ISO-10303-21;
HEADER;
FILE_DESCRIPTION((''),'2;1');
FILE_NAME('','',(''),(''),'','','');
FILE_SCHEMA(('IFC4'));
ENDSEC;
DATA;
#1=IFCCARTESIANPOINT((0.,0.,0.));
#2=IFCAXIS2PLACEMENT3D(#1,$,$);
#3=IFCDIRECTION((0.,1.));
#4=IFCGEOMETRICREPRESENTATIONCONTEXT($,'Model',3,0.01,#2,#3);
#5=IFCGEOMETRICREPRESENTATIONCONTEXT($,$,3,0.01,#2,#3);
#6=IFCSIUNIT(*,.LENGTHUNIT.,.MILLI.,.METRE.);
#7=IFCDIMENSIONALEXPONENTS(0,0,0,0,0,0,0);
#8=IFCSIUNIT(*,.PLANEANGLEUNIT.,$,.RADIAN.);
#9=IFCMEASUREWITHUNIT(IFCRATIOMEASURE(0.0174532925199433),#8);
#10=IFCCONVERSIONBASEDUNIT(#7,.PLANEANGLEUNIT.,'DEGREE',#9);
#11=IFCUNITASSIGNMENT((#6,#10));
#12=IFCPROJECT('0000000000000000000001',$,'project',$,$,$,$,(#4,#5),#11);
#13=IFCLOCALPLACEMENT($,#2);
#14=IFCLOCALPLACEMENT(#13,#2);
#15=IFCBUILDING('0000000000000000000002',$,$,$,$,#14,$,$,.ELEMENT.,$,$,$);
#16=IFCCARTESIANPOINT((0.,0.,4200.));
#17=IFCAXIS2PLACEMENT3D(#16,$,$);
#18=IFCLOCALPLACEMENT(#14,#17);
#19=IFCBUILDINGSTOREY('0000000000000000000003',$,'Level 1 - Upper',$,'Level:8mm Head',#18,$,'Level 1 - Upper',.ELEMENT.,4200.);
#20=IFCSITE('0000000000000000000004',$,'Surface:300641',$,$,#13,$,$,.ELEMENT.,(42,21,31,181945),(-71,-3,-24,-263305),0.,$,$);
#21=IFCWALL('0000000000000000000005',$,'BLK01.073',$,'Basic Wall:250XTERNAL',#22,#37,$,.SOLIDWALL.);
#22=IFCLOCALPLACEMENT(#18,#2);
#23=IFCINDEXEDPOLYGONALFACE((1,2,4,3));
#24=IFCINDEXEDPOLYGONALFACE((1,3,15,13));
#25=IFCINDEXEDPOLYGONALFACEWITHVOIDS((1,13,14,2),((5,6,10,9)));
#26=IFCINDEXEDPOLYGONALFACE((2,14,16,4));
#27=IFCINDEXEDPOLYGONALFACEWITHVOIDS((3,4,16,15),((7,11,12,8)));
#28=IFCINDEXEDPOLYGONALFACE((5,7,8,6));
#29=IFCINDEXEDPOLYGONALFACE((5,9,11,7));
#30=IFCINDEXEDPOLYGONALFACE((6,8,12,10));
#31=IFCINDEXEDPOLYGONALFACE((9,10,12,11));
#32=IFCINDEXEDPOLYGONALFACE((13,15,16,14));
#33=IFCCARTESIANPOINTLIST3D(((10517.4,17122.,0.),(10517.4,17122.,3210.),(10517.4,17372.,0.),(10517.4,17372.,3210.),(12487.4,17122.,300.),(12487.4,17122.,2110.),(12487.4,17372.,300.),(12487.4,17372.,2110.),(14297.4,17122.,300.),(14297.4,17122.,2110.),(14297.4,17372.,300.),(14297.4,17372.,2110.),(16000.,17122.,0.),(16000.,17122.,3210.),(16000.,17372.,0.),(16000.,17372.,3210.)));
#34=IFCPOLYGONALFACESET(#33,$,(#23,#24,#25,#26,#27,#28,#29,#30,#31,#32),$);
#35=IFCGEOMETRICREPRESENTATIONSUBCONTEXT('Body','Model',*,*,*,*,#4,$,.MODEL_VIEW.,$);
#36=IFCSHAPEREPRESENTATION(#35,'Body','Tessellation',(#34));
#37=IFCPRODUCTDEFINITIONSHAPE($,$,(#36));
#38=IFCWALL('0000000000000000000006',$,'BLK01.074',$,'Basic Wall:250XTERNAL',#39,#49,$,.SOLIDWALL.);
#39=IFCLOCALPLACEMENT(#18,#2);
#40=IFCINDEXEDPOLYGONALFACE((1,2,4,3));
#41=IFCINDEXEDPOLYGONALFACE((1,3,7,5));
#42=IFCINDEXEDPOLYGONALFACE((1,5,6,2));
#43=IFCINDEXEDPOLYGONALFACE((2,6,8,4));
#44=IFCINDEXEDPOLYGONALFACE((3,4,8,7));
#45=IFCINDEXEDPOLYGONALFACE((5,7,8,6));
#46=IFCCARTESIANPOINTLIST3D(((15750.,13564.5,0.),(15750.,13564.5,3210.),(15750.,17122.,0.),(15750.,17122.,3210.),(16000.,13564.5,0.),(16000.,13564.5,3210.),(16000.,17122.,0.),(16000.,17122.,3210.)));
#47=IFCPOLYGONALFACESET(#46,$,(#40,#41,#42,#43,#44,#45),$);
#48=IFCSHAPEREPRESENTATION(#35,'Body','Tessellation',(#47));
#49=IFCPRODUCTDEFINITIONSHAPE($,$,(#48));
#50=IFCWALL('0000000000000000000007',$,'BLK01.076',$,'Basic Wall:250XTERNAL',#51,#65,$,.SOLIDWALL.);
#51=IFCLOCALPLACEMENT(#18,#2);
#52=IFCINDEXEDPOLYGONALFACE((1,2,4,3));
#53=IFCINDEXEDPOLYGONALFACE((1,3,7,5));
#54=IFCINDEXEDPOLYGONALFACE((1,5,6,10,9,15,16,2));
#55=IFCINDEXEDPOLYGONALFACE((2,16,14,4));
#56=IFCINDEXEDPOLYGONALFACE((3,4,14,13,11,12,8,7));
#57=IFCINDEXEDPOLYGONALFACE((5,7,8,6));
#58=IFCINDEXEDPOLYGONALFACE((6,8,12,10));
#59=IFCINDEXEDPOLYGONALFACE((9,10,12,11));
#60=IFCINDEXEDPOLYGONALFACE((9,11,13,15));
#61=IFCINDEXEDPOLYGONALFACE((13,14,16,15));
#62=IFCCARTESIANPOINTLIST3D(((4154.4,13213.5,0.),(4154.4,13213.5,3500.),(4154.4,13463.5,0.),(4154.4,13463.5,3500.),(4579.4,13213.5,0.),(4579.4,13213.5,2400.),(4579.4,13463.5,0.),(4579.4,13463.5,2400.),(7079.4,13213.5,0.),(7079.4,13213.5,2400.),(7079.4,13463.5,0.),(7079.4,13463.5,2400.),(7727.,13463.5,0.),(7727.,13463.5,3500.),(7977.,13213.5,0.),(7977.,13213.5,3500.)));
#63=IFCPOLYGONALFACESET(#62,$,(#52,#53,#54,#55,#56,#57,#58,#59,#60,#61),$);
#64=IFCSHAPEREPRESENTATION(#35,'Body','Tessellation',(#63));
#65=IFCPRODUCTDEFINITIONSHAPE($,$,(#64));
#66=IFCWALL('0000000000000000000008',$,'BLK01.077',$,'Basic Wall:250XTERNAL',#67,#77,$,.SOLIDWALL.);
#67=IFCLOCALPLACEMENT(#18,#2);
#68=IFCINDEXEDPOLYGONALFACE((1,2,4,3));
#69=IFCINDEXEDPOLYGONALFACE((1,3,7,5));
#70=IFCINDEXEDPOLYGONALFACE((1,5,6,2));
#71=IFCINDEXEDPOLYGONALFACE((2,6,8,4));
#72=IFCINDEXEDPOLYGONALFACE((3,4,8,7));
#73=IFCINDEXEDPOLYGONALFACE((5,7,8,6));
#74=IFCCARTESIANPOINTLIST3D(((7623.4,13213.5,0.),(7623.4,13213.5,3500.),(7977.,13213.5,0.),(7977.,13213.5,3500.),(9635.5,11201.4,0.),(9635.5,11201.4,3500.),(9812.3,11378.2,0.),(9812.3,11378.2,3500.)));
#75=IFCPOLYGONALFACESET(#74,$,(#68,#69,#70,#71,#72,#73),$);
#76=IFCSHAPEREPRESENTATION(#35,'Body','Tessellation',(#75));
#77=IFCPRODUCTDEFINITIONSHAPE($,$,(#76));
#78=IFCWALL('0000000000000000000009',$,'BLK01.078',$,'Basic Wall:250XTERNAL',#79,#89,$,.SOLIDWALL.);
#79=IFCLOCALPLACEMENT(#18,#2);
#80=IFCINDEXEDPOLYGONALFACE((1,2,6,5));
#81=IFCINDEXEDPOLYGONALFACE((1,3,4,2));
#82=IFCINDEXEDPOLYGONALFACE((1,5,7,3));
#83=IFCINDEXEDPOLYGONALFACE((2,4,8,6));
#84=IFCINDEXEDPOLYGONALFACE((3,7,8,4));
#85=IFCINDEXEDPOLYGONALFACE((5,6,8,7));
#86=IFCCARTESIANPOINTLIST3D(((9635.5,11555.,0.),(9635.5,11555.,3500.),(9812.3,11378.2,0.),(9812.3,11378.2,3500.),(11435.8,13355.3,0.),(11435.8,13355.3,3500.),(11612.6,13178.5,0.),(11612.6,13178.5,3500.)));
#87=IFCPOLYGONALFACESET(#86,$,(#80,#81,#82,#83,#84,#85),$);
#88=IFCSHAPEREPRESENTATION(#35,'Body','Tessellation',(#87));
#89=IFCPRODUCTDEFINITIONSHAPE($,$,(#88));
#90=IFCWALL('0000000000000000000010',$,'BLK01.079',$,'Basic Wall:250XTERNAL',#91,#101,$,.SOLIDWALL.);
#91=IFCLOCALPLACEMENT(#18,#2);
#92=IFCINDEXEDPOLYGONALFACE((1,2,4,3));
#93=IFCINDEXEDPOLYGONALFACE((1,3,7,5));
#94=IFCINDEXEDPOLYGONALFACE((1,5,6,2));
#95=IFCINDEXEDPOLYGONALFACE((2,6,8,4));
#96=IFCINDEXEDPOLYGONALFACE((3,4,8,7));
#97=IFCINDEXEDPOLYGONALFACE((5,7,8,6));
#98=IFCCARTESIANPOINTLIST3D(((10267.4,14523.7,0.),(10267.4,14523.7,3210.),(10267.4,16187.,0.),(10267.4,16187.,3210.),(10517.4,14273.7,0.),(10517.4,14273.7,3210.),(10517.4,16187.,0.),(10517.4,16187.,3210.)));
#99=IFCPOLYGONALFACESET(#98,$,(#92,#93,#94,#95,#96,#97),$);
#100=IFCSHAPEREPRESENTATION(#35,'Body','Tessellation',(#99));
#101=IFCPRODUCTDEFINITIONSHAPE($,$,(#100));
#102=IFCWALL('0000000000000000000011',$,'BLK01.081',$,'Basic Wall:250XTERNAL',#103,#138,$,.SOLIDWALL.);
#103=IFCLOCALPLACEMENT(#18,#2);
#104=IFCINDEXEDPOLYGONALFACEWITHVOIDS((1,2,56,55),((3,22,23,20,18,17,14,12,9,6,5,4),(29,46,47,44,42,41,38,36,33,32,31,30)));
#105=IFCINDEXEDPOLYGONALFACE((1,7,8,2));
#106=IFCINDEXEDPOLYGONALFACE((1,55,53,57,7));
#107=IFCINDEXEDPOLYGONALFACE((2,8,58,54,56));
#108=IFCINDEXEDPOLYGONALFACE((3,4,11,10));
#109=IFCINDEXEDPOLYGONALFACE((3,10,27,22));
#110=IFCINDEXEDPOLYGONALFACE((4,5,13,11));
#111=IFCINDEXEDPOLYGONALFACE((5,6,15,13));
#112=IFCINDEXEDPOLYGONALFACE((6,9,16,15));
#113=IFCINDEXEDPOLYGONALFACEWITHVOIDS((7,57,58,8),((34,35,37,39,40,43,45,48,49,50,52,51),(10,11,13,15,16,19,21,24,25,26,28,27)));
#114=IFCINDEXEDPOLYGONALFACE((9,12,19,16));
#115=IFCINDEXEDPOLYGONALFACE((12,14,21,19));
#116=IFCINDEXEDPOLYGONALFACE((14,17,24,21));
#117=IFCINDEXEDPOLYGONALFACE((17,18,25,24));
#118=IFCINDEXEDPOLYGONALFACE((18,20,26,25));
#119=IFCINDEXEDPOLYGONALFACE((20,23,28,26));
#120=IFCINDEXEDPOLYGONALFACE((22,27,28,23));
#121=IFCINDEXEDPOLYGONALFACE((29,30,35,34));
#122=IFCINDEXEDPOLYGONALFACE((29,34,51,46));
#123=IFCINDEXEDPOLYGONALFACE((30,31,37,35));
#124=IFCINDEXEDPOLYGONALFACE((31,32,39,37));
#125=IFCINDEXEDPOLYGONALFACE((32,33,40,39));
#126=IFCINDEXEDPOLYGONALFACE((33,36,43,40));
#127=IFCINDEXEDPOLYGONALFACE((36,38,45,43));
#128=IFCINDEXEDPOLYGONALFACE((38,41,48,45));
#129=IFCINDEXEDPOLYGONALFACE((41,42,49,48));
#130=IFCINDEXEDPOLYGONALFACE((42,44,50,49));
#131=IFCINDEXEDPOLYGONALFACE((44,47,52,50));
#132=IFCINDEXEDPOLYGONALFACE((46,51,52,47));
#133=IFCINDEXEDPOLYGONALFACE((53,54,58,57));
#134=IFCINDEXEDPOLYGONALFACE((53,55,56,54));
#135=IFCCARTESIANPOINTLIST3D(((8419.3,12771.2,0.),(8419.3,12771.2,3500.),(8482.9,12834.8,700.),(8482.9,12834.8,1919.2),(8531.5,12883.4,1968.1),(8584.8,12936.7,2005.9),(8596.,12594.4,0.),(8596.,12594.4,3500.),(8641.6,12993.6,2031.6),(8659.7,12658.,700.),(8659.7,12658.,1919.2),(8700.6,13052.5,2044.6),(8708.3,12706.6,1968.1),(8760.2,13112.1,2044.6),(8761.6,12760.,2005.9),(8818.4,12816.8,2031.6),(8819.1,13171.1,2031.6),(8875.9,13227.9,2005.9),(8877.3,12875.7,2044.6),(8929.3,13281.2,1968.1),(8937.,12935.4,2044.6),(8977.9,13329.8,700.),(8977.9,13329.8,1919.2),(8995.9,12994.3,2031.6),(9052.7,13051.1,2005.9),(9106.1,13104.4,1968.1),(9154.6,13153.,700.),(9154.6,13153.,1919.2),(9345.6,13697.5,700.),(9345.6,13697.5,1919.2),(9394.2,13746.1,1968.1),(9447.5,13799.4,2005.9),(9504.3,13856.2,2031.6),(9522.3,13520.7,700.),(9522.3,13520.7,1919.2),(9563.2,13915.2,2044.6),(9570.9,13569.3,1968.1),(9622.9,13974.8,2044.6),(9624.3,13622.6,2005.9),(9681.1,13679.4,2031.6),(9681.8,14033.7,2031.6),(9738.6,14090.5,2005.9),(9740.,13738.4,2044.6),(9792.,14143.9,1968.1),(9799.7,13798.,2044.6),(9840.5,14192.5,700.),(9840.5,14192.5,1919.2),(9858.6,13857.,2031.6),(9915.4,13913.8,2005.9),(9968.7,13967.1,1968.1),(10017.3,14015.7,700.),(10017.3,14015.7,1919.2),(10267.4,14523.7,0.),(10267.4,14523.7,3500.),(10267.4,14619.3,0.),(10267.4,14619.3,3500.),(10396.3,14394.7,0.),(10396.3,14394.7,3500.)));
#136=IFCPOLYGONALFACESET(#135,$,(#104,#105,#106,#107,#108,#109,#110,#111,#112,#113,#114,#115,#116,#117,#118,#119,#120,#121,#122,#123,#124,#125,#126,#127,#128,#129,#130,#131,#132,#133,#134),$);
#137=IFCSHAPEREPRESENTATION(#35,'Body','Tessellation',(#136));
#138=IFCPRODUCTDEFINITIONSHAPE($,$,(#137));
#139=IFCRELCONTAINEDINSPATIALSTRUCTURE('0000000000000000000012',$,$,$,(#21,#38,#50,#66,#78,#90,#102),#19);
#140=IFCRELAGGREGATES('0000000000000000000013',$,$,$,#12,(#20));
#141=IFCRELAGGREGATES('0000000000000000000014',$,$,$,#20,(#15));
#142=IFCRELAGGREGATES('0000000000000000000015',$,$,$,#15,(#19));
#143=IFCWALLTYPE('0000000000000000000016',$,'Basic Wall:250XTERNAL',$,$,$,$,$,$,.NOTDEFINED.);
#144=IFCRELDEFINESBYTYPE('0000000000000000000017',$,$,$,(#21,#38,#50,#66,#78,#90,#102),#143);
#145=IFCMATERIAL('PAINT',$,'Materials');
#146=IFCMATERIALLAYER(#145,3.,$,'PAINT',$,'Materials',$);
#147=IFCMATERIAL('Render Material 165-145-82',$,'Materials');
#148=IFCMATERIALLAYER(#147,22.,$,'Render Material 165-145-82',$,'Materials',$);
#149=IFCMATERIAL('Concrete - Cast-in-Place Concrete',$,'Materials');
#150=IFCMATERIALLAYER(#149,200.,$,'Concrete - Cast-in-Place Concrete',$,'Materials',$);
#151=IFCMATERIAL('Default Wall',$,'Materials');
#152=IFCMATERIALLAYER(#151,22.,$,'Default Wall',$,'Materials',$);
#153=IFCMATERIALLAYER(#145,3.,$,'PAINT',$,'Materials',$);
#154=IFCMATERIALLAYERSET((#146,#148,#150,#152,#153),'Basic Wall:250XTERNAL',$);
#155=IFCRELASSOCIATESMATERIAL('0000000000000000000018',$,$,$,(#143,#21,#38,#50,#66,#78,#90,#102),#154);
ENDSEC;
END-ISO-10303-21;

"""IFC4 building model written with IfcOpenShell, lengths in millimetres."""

from ifc_helpers import new_model, entity, si_unit, converted_unit, direction, frame, frame_2d, origin, place, context, subcontext, project, spatial, polyline, circle_curve, parameter, trimmed, segment, composite_curve, rectangle, outline, extrude, clip, halfspace, bounded_halfspace, material, layer, layer_set, layer_usage, type_object, element, save


model = new_model("IFC4")

# Units and contexts
model_context = context("Model", 3, precision=0.01, world=origin(), true_north=direction((0.0, 1.0)))
context_of_model = context(None, 3, precision=0.01, world=origin(), true_north=direction((0.0, 1.0)))
body_context = subcontext(model_context, "Body", "Model", "MODEL_VIEW")
ifc_project = project(units=[si_unit("LENGTHUNIT", "METRE", prefix="MILLI"), converted_unit("PLANEANGLEUNIT", "DEGREE", entity("IfcRatioMeasure", 0.0174532925199433), si_unit("PLANEANGLEUNIT", "RADIAN"), dimensions=[0, 0, 0, 0, 0, 0, 0])], contexts=[model_context, context_of_model])

# Site, building, storey
site_placement = place(None, origin())
site = spatial("IfcSite", under=ifc_project, at=site_placement, Name="Surface:300641", CompositionType="ELEMENT", RefLatitude=(42, 21, 31, 181945), RefLongitude=(-71, -3, -24, -263305), RefElevation=0.0)
building_placement = place(site_placement, origin())
building = spatial("IfcBuilding", under=site, at=building_placement, CompositionType="ELEMENT")
storey_placement = place(building_placement, frame((0.0, 0.0, 4200.0)))
storey = spatial("IfcBuildingStorey", under=building, at=storey_placement, Name="Level 1 - Upper", ObjectType="Level:8mm Head", LongName="Level 1 - Upper", CompositionType="ELEMENT", Elevation=4200.0)

# Shared definitions
ifc_material_1 = material(Name="PAINT", Category="Materials")
ifc_layer_1 = layer(ifc_material_1, 3.0, Name="PAINT", Category="Materials")
ifc_material_2 = material(Name="Render Material 165-145-82", Category="Materials")
ifc_layer_2 = layer(ifc_material_2, 22.0, Name="Render Material 165-145-82", Category="Materials")
ifc_material_3 = material(Name="Concrete - Cast-in-Place Concrete", Category="Materials")
ifc_layer_3 = layer(ifc_material_3, 200.0, Name="Concrete - Cast-in-Place Concrete", Category="Materials")
ifc_material_4 = material(Name="Default Wall", Category="Materials")
ifc_layer_4 = layer(ifc_material_4, 22.0, Name="Default Wall", Category="Materials")
ifc_layer_5 = layer(ifc_material_1, 3.0, Name="PAINT", Category="Materials")
ifc_layer_set_1 = layer_set([ifc_layer_1, ifc_layer_2, ifc_layer_3, ifc_layer_4, ifc_layer_5], Name="Basic Wall:250XTERNAL")
wall_type_1 = type_object("IfcWallType", Name="Basic Wall:250XTERNAL", PredefinedType="NOTDEFINED", material=ifc_layer_set_1)

# Wall, opening
ifc_layer_usage_1 = layer_usage(ifc_layer_set_1, "AXIS2", "NEGATIVE", 125.0)
wall_1_placement = place(storey_placement, frame((10517.4, 17247.0, 0.0)))
wall_1 = element("IfcWall", 1, at=wall_1_placement, inside=storey, type_object=wall_type_1, material=ifc_layer_usage_1, Name="BLK01.073", ObjectType="Basic Wall:250XTERNAL", PredefinedType="SOLIDWALL", context=body_context, shape_type="Clipping", body=[
    clip(clip(extrude(rectangle(XDim=5482.6, YDim=250.0, at=frame_2d((2741.3, 0.0), x_axis=(-1.0, 0.0))), origin(), (0.0, 0.0, 1.0), 3210.0), bounded_halfspace(frame((0.0, -125.0, 3210.0), z_axis=(0.0, 0.0, -1.0), x_axis=(0.0, -1.0, 0.0)), True, frame((0.0, -125.0, 3210.0)), polyline([(0.0, 0.0), (5232.6, 0.0), (5482.6, 0.0), (5482.6, 250.0), (0.0, 250.0), (0.0, 0.0)]))), halfspace(frame((0.0, 0.0, -400.0)), True)),
])
opening_1_placement = place(wall_1_placement, frame((1970.0, -1649.0, 300.0)))
element("IfcOpeningElement", 2, at=opening_1_placement, cuts=wall_1, ObjectType="Opening", PredefinedType="OPENING", context=body_context, shape_type="SweptSolid", body=[
    extrude(rectangle(XDim=1810.0, YDim=1810.0, at=frame_2d((0.0, 0.0), x_axis=(0.0, 1.0))), frame((905.0, 0.0, 905.0), z_axis=(0.0, 1.0, 0.0), x_axis=(1.0, 0.0, 0.0)), (0.0, 0.0, 1.0), 3048.0),
])

# Wall
ifc_layer_usage_2 = layer_usage(ifc_layer_set_1, "AXIS2", "NEGATIVE", 125.0)
wall_2_placement = place(storey_placement, frame((15875.0, 17122.0, 0.0), z_axis=(0.0, 0.0, 1.0), x_axis=(0.0, -1.0, 0.0)))
element("IfcWall", 3, at=wall_2_placement, inside=storey, type_object=wall_type_1, material=ifc_layer_usage_2, Name="BLK01.074", ObjectType="Basic Wall:250XTERNAL", PredefinedType="SOLIDWALL", context=body_context, shape_type="Clipping", body=[
    clip(clip(extrude(rectangle(XDim=3557.5, YDim=250.0, at=frame_2d((1778.8, 0.0), x_axis=(-1.0, 0.0))), origin(), (0.0, 0.0, 1.0), 3210.0), bounded_halfspace(frame((0.0, 125.0, 3210.0), z_axis=(0.0, 0.0, -1.0), x_axis=(1.0, 0.0, 0.0)), True, frame((0.0, 125.0, 3210.0)), polyline([(0.0, 0.0), (0.0, -250.0), (3557.5, -250.0), (3557.5, 0.0), (0.0, 0.0)]))), halfspace(frame((0.0, 0.0, -400.0)), True)),
])

# Wall, opening
ifc_layer_usage_3 = layer_usage(ifc_layer_set_1, "AXIS2", "NEGATIVE", 125.0)
wall_3_placement = place(storey_placement, frame((4154.4, 13338.5, 0.0)))
wall_3 = element("IfcWall", 4, at=wall_3_placement, inside=storey, type_object=wall_type_1, material=ifc_layer_usage_3, Name="BLK01.076", ObjectType="Basic Wall:250XTERNAL", PredefinedType="SOLIDWALL", context=body_context, shape_type="Clipping", body=[
    clip(extrude(outline(polyline([(0.0, -125.0), (3469.0, -125.0), (3822.5, -125.0), (3572.5, 125.0), (0.0, 125.0), (0.0, -125.0)])), origin(), (0.0, 0.0, 1.0), 3500.0), halfspace(origin(), True)),
])
opening_2_placement = place(wall_3_placement, frame((2925.0, 125.0, 0.0)))
element("IfcOpeningElement", 5, at=opening_2_placement, cuts=wall_3, ObjectType="Opening", PredefinedType="OPENING", context=body_context, shape_type="SweptSolid", body=[
    extrude(rectangle(XDim=2400.0, YDim=2500.0, at=frame_2d((1200.0, 1250.0), x_axis=(-1.0, 0.0))), frame((0.0, 0.0, 0.0), z_axis=(0.0, -1.0, 0.0), x_axis=(0.0, 0.0, 1.0)), (0.0, 0.0, 1.0), 250.0),
])

# Walls
ifc_layer_usage_4 = layer_usage(ifc_layer_set_1, "AXIS2", "NEGATIVE", 125.0)
wall_4_placement = place(storey_placement, frame((7711.8, 13301.9, 0.0), z_axis=(0.0, 0.0, 1.0), x_axis=(0.707107, -0.707107, 0.0)))
element("IfcWall", 6, at=wall_4_placement, inside=storey, type_object=wall_type_1, material=ifc_layer_usage_4, Name="BLK01.077", ObjectType="Basic Wall:250XTERNAL", PredefinedType="SOLIDWALL", context=body_context, shape_type="Clipping", body=[
    clip(extrude(outline(polyline([(2845.5, -125.0), (2845.5, 0.0), (2845.5, 125.0), (2595.5, 125.0), (1125.5, 125.0), (875.5, 125.0), (250.0, 125.0), (0.0, -125.0), (2845.5, -125.0)])), origin(), (0.0, 0.0, 1.0), 3500.0), halfspace(origin(), True)),
])
ifc_layer_usage_5 = layer_usage(ifc_layer_set_1, "AXIS2", "NEGATIVE", 125.0)
wall_5_placement = place(storey_placement, frame((9723.9, 11466.6, 0.0), z_axis=(0.0, 0.0, 1.0), x_axis=(0.707107, 0.707107, 0.0)))
element("IfcWall", 7, at=wall_5_placement, inside=storey, type_object=wall_type_1, material=ifc_layer_usage_5, Name="BLK01.078", ObjectType="Basic Wall:250XTERNAL", PredefinedType="SOLIDWALL", context=body_context, shape_type="Clipping", body=[
    clip(extrude(rectangle(XDim=2546.0, YDim=250.0, at=frame_2d((1273.0, 0.0), x_axis=(-1.0, 0.0))), origin(), (0.0, 0.0, 1.0), 3500.0), halfspace(origin(), True)),
])
ifc_layer_usage_6 = layer_usage(ifc_layer_set_1, "AXIS2", "NEGATIVE", 125.0)
wall_6_placement = place(storey_placement, frame((10392.4, 16187.0, 0.0), z_axis=(0.0, 0.0, 1.0), x_axis=(0.0, -1.0, 0.0)))
element("IfcWall", 8, at=wall_6_placement, inside=storey, type_object=wall_type_1, material=ifc_layer_usage_6, Name="BLK01.079", ObjectType="Basic Wall:250XTERNAL", PredefinedType="SOLIDWALL", context=body_context, shape_type="Clipping", body=[
    clip(clip(extrude(outline(polyline([(1663.3, -125.0), (1792.3, 4.0), (1913.3, 125.0), (1735.1, 125.0), (0.0, 125.0), (0.0, -125.0), (1567.7, -125.0), (1663.3, -125.0)])), origin(), (0.0, 0.0, 1.0), 3210.0), bounded_halfspace(frame((0.0, -125.0, 3210.0), z_axis=(0.0, 0.0, -1.0), x_axis=(1.0, 0.0, 0.0)), True, frame((0.0, -125.0, 3210.0)), polyline([(0.0, 0.0), (1663.3, 0.0), (1913.3, 250.0), (0.0, 250.0), (0.0, 0.0)]))), halfspace(origin(), True)),
])

# Wall, openings
ifc_layer_usage_7 = layer_usage(ifc_layer_set_1, "AXIS2", "POSITIVE", -125.0)
wall_7_placement = place(storey_placement, frame((8507.6, 12682.8, 0.0), z_axis=(0.0, 0.0, 1.0), x_axis=(0.707107, 0.707107, 0.0)))
wall_7 = element("IfcWall", 9, at=wall_7_placement, inside=storey, type_object=wall_type_1, material=ifc_layer_usage_7, Name="BLK01.081", ObjectType="Basic Wall:250XTERNAL", PredefinedType="SOLIDWALL", context=body_context, shape_type="Clipping", body=[
    clip(extrude(outline(polyline([(2546.0, -125.0), (2546.0, 57.4), (2613.6, 125.0), (0.0, 125.0), (0.0, -125.0), (2546.0, -125.0)])), origin(), (0.0, 0.0, 1.0), 3500.0), halfspace(origin(), True)),
])
opening_3_placement = place(wall_7_placement, frame((790.0, 125.0, 700.0)))
element("IfcOpeningElement", 10, at=opening_3_placement, cuts=wall_7, ObjectType="Opening", PredefinedType="OPENING", context=body_context, shape_type="SweptSolid", body=[
    extrude(outline(composite_curve([segment(polyline([(0.0, 0.0), (1219.2, 0.0)]), True, "CONTINUOUS"), segment(trimmed(circle_curve(frame_2d((800.4, 350.0), x_axis=(0.0, 1.0)), 545.8), [parameter(230.112671)], [parameter(309.887329)], True, "PARAMETER"), True, "CONTINUOUS"), segment(polyline([(1219.2, 700.0), (0.0, 700.0)]), True, "CONTINUOUS"), segment(polyline([(0.0, 700.0), (0.0, 0.0)]), True, "CONTINUOUS")], self_intersect=False)), frame((0.0, 0.0, 0.0), z_axis=(0.0, -1.0, 0.0), x_axis=(0.0, 0.0, 1.0)), (0.0, 0.0, 1.0), 250.0),
])
opening_4_placement = place(wall_7_placement, frame((2010.0, 125.0, 700.0)))
element("IfcOpeningElement", 11, at=opening_4_placement, cuts=wall_7, ObjectType="Opening", PredefinedType="OPENING", context=body_context, shape_type="SweptSolid", body=[
    extrude(outline(composite_curve([segment(polyline([(0.0, 0.0), (1219.2, 0.0)]), True, "CONTINUOUS"), segment(trimmed(circle_curve(frame_2d((800.4, 350.0), x_axis=(0.0, 1.0)), 545.8), [parameter(230.112671)], [parameter(309.887329)], True, "PARAMETER"), True, "CONTINUOUS"), segment(polyline([(1219.2, 700.0), (0.0, 700.0)]), True, "CONTINUOUS"), segment(polyline([(0.0, 700.0), (0.0, 0.0)]), True, "CONTINUOUS")], self_intersect=False)), frame((0.0, 0.0, 0.0), z_axis=(0.0, -1.0, 0.0), x_axis=(0.0, 0.0, 1.0)), (0.0, 0.0, 1.0), 250.0),
])

save(model, "model.ifc")
